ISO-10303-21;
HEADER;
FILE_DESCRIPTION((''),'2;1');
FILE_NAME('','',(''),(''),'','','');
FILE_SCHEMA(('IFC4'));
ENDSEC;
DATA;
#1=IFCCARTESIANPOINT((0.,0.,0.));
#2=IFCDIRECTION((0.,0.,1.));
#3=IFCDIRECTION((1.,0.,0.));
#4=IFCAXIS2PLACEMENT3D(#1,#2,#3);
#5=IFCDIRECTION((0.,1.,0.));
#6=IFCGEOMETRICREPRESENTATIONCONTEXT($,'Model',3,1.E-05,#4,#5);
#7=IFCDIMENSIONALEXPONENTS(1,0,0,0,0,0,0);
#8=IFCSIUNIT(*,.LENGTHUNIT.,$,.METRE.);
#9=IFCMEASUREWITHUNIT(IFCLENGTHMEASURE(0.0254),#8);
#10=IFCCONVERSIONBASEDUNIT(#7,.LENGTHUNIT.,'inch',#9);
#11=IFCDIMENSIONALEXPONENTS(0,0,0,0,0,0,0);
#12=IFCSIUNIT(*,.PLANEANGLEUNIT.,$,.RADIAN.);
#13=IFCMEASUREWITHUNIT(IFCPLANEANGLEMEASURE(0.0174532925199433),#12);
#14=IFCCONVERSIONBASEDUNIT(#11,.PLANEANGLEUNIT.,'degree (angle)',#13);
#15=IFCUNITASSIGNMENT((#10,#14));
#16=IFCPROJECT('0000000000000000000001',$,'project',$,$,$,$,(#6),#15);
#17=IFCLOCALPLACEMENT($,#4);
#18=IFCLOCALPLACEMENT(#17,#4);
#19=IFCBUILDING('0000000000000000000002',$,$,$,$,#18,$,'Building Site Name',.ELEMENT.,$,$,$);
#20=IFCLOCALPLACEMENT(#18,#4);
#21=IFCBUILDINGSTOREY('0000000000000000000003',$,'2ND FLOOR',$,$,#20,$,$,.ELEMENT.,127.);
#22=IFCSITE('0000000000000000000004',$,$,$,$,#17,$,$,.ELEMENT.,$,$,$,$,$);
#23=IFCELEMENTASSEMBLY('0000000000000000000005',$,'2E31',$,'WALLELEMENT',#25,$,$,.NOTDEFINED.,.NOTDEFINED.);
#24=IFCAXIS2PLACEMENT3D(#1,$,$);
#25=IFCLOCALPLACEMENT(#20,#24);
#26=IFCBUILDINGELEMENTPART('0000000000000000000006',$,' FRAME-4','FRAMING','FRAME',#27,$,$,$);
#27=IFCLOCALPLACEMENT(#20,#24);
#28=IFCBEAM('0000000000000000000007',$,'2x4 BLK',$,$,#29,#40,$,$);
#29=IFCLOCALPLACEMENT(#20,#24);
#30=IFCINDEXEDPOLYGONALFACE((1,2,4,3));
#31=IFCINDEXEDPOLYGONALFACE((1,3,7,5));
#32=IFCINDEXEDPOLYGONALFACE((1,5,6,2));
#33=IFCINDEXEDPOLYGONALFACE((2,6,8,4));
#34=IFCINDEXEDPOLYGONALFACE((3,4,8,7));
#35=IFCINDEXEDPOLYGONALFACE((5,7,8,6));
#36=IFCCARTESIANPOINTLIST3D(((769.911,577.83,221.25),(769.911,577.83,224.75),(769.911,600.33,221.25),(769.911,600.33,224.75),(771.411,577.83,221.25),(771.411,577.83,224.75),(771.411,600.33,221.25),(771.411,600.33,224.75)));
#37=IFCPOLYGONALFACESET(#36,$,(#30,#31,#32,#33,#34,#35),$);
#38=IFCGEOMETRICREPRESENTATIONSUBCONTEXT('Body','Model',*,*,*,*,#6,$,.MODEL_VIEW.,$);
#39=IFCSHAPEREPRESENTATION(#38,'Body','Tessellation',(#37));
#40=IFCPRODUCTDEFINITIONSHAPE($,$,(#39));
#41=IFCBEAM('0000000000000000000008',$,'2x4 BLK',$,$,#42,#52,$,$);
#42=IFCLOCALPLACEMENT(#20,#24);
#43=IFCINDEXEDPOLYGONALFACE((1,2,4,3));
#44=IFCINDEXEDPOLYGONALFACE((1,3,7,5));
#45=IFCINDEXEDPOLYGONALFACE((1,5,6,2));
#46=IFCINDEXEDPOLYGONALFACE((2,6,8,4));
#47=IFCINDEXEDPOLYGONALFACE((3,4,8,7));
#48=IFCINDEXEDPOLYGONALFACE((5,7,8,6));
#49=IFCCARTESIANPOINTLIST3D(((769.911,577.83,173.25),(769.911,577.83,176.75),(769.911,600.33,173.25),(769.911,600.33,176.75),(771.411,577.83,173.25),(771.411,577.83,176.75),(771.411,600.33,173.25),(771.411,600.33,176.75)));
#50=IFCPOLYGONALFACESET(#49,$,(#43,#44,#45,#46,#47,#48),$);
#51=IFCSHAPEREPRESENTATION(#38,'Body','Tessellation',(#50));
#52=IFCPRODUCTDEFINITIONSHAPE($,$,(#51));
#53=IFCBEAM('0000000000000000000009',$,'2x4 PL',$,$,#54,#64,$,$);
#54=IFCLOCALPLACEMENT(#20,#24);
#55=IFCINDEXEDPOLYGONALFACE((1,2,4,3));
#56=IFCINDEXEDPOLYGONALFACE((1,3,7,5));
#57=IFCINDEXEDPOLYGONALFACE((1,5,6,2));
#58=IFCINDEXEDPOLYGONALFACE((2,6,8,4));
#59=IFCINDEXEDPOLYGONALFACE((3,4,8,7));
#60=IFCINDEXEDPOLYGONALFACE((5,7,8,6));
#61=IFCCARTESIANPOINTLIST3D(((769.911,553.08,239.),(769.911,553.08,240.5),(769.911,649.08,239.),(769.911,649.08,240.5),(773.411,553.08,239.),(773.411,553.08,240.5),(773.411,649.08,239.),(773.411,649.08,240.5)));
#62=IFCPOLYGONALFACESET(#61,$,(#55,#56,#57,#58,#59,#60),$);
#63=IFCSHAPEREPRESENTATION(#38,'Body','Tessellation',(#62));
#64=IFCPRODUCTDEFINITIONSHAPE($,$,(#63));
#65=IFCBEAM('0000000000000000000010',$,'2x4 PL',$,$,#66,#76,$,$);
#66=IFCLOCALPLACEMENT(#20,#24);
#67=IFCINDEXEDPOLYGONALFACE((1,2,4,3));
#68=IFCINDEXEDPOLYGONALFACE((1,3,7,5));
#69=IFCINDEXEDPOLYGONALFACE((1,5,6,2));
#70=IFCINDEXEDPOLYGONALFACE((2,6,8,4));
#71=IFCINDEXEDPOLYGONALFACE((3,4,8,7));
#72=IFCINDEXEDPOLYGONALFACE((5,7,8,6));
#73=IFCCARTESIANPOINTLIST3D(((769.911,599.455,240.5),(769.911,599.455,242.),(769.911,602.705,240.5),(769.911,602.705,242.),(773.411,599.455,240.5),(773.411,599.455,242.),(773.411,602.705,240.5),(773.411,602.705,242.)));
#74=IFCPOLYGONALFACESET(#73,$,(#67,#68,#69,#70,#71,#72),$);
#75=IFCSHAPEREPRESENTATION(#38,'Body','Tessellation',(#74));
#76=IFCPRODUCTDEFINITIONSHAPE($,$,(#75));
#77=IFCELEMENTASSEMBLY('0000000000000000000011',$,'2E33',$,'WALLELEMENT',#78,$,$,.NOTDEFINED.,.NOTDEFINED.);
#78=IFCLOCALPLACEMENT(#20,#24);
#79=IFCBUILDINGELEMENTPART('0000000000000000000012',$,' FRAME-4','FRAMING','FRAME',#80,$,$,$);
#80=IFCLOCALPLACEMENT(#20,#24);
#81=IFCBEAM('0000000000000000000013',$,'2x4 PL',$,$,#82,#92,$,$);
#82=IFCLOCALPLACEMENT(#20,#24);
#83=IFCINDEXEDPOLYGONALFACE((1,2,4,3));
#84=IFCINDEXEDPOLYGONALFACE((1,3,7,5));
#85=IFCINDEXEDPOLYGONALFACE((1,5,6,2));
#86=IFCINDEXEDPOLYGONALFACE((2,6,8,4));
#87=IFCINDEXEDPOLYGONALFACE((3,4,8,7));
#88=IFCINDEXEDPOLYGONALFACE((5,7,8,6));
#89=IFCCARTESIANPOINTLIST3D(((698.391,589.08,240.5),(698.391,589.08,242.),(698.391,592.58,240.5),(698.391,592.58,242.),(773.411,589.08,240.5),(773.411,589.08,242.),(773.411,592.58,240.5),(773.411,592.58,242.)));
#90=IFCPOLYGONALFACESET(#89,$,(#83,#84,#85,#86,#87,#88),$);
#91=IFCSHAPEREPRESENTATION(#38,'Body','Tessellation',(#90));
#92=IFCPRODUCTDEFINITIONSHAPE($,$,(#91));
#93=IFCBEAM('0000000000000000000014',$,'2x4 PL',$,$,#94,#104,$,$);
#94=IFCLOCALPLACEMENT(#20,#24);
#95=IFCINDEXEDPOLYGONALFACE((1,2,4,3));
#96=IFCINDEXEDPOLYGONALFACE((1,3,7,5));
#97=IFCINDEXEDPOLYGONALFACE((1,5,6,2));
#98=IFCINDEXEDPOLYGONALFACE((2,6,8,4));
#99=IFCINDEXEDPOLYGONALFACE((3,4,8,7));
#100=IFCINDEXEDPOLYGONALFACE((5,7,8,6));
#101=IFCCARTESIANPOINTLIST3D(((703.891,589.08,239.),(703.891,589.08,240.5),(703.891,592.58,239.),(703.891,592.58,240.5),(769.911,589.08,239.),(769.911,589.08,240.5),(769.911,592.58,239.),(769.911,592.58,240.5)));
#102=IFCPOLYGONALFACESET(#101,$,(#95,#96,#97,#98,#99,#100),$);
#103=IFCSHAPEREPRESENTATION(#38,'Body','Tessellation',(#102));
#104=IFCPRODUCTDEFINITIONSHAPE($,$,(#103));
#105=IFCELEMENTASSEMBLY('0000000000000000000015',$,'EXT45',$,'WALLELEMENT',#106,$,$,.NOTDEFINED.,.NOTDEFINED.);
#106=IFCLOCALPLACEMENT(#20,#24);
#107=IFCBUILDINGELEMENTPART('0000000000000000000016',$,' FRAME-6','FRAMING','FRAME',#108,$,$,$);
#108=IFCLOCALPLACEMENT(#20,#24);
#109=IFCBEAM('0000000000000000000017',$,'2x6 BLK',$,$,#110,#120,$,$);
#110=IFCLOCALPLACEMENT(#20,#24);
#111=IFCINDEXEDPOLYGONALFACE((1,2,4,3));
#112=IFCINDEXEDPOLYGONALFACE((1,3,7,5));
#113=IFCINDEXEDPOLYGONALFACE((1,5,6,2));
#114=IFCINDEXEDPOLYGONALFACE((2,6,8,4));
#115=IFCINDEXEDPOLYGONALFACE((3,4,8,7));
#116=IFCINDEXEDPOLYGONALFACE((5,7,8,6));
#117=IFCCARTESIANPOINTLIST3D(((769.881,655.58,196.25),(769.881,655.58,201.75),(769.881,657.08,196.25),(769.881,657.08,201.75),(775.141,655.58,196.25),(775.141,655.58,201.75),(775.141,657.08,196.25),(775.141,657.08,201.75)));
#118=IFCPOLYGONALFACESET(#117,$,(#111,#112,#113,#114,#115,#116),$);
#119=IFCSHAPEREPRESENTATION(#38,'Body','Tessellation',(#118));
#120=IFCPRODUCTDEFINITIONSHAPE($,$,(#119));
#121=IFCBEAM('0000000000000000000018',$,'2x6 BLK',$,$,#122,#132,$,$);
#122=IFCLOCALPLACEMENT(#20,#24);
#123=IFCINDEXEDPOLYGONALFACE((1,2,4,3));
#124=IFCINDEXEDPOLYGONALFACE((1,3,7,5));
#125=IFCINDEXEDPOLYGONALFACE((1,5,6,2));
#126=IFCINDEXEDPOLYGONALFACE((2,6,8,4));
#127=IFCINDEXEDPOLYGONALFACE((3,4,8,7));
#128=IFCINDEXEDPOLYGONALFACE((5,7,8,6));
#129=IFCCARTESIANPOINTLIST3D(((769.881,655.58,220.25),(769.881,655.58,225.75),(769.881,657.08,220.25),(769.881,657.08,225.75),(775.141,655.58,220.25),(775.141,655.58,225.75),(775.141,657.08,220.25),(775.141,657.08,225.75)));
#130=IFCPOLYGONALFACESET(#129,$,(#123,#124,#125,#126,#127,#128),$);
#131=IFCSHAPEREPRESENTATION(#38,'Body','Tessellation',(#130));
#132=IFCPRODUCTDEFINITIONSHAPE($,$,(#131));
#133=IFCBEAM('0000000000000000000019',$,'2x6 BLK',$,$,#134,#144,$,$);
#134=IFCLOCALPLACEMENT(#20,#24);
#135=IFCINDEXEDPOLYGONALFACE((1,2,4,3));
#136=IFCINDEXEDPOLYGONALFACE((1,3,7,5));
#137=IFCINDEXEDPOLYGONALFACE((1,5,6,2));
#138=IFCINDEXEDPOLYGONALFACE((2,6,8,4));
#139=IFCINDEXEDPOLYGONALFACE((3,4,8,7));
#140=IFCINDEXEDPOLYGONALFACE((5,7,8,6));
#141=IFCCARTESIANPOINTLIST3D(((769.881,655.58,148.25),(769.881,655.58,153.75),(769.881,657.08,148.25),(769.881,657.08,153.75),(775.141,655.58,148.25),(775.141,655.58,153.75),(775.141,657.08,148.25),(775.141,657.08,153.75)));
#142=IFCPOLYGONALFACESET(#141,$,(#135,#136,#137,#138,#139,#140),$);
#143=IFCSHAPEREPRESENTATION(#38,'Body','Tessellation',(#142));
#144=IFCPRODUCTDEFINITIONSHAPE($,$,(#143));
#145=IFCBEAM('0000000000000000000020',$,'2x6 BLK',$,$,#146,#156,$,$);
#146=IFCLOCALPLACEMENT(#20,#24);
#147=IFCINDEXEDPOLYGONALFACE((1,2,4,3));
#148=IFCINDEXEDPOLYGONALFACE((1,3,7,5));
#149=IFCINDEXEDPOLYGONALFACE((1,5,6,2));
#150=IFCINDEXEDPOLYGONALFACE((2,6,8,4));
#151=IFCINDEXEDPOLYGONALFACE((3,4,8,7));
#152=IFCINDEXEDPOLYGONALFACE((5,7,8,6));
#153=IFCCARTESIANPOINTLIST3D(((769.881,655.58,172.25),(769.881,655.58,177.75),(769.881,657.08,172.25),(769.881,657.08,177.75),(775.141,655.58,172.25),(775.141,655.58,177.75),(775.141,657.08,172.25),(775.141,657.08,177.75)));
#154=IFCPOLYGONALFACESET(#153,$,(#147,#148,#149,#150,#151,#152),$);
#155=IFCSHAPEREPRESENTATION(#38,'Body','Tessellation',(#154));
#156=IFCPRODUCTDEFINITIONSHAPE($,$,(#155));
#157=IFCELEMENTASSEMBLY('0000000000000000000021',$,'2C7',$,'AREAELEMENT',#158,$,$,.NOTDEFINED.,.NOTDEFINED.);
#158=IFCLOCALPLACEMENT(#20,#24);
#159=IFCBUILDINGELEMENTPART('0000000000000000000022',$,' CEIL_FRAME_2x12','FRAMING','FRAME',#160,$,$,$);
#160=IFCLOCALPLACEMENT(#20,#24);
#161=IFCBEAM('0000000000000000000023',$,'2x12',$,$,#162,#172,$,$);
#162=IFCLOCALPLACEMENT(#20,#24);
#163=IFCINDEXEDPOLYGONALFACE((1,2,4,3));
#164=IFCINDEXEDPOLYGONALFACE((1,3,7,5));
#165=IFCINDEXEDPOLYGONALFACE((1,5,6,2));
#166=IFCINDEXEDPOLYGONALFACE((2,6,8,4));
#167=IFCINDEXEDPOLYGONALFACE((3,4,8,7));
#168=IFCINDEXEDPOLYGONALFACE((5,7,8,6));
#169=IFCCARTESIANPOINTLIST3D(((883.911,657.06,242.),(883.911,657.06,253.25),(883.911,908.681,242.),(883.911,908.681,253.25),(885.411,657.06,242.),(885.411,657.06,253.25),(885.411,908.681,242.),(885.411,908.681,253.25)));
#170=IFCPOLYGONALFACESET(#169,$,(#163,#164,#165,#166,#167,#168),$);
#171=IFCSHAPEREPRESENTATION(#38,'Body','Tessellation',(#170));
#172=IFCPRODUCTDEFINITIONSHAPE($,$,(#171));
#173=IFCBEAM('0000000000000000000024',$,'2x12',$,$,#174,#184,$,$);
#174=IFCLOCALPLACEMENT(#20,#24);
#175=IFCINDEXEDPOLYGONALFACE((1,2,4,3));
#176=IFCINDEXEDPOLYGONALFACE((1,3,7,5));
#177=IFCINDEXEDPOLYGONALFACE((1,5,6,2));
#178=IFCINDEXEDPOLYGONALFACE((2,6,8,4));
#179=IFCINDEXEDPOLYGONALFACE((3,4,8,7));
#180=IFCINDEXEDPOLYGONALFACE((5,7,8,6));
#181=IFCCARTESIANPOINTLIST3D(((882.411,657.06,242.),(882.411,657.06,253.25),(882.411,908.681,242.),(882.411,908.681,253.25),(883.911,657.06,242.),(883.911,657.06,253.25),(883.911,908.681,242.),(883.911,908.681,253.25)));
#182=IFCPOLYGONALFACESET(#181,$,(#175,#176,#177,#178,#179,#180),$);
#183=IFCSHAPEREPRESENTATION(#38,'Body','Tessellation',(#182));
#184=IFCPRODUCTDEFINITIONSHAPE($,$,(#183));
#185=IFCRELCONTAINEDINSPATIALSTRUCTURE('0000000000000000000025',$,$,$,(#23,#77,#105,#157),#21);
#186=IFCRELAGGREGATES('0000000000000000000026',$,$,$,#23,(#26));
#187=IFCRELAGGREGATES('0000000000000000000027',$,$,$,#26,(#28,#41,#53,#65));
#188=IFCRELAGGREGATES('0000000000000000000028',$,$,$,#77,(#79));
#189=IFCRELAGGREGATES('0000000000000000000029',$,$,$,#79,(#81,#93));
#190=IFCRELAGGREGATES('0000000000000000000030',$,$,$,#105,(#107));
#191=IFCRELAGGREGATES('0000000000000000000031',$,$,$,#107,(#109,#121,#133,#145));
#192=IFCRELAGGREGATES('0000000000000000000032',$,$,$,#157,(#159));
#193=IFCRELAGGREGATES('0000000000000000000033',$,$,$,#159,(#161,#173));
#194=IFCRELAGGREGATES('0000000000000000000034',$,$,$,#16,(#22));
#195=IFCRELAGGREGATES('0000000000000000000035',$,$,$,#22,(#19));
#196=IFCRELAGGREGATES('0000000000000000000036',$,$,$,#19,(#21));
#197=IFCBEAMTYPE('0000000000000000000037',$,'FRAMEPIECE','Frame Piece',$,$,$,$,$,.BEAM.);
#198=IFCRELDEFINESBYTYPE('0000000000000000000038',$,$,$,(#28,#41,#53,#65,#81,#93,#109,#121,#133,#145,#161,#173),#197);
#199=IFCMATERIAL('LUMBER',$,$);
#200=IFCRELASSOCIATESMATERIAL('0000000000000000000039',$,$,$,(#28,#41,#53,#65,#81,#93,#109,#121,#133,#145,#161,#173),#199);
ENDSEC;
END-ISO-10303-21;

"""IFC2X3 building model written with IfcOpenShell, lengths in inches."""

from ifc_helpers import new_model, entity, si_unit, converted_unit, direction, frame, frame_2d, origin_with_axes, place, context, subcontext, project, spatial, rectangle, extrude, material, type_object, element, aggregate, save


model = new_model("IFC2X3")

# Units and contexts
model_context = context("Model", 3, precision=1e-05, world=origin_with_axes(), true_north=direction((0.0, 1.0, 0.0)))
body_context = subcontext(model_context, "Body", "Model", "MODEL_VIEW")
ifc_project = project(units=[converted_unit("LENGTHUNIT", "inch", entity("IfcLengthMeasure", 0.0254), si_unit("LENGTHUNIT", "METRE"), dimensions=[1, 0, 0, 0, 0, 0, 0]), converted_unit("PLANEANGLEUNIT", "degree (angle)", entity("IfcPlaneAngleMeasure", 0.0174532925199433), si_unit("PLANEANGLEUNIT", "RADIAN"), dimensions=[0, 0, 0, 0, 0, 0, 0])], contexts=[model_context])

# Site, building, storey
site_placement = place(None, origin_with_axes())
site = spatial("IfcSite", under=ifc_project, at=site_placement, CompositionType="ELEMENT")
building_placement = place(site_placement, origin_with_axes())
building = spatial("IfcBuilding", under=site, at=building_placement, LongName="Building Site Name", CompositionType="ELEMENT")
storey_placement = place(building_placement, origin_with_axes())
storey = spatial("IfcBuildingStorey", under=building, at=storey_placement, Name="2ND FLOOR", CompositionType="ELEMENT", Elevation=127.0)

# Shared definitions
ifc_material = material(Name="LUMBER")
beam_type = type_object("IfcBeamType", Name="FRAMEPIECE", Description="Frame Piece", PredefinedType="BEAM")

# Element assembly, building element part
assembly_1_placement = place(storey_placement, origin_with_axes())
assembly_1 = element("IfcElementAssembly", 1, at=assembly_1_placement, inside=storey, Name="2E31", ObjectType="WALLELEMENT", AssemblyPlace="NOTDEFINED", PredefinedType="NOTDEFINED")
building_element_part_1 = element("IfcBuildingElementPart", 2, Name=" FRAME-4", Description="FRAMING", ObjectType="FRAME")
aggregate(assembly_1, [building_element_part_1])

# Beams
beam_1_placement = place(assembly_1_placement, frame((770.661, 600.33, 223.0), z_axis=(0.0, -1.0, 0.0), x_axis=(-1.0, 0.0, 0.0)))
beam_1 = element("IfcBeam", 3, at=beam_1_placement, type_object=beam_type, material=ifc_material, Name="2x4 BLK", context=body_context, shape_type="SweptSolid", body=[
    extrude(rectangle(XDim=1.5, YDim=3.5, at=frame_2d((0.0, 0.0), x_axis=(-1.0, 0.0))), origin_with_axes(), (0.0, 0.0, 1.0), 22.5),
])
beam_2_placement = place(assembly_1_placement, frame((770.661, 600.33, 175.0), z_axis=(0.0, -1.0, 0.0), x_axis=(-1.0, 0.0, 0.0)))
beam_2 = element("IfcBeam", 4, at=beam_2_placement, type_object=beam_type, material=ifc_material, Name="2x4 BLK", context=body_context, shape_type="SweptSolid", body=[
    extrude(rectangle(XDim=1.5, YDim=3.5, at=frame_2d((0.0, 0.0), x_axis=(-1.0, 0.0))), origin_with_axes(), (0.0, 0.0, 1.0), 22.5),
])
beam_3_placement = place(assembly_1_placement, frame((771.661, 649.08, 239.75), z_axis=(0.0, -1.0, 0.0), x_axis=(0.0, 0.0, -1.0)))
beam_3 = element("IfcBeam", 5, at=beam_3_placement, type_object=beam_type, material=ifc_material, Name="2x4 PL", context=body_context, shape_type="SweptSolid", body=[
    extrude(rectangle(XDim=1.5, YDim=3.5, at=frame_2d((0.0, 0.0), x_axis=(-1.0, 0.0))), origin_with_axes(), (0.0, 0.0, 1.0), 96.0),
])
beam_4_placement = place(assembly_1_placement, frame((771.661, 602.705, 241.25), z_axis=(0.0, -1.0, 0.0), x_axis=(0.0, 0.0, -1.0)))
beam_4 = element("IfcBeam", 6, at=beam_4_placement, type_object=beam_type, material=ifc_material, Name="2x4 PL", context=body_context, shape_type="SweptSolid", body=[
    extrude(rectangle(XDim=1.5, YDim=3.5, at=frame_2d((0.0, 0.0), x_axis=(-1.0, 0.0))), origin_with_axes(), (0.0, 0.0, 1.0), 3.25),
])
aggregate(building_element_part_1, [beam_1, beam_2, beam_3, beam_4])

# Element assemblies, building element parts, beams
assembly_2_placement = place(storey_placement, origin_with_axes())
assembly_2 = element("IfcElementAssembly", 7, at=assembly_2_placement, inside=storey, Name="2E33", ObjectType="WALLELEMENT", AssemblyPlace="NOTDEFINED", PredefinedType="NOTDEFINED")
building_element_part_2 = element("IfcBuildingElementPart", 8, Name=" FRAME-4", Description="FRAMING", ObjectType="FRAME")
aggregate(assembly_2, [building_element_part_2])
beam_5_placement = place(assembly_2_placement, frame((773.411, 590.83, 241.25), z_axis=(-1.0, 0.0, 0.0), x_axis=(0.0, 0.0, -1.0)))
beam_5 = element("IfcBeam", 9, at=beam_5_placement, type_object=beam_type, material=ifc_material, Name="2x4 PL", context=body_context, shape_type="SweptSolid", body=[
    extrude(rectangle(XDim=1.5, YDim=3.5, at=frame_2d((0.0, 0.0), x_axis=(-1.0, 0.0))), origin_with_axes(), (0.0, 0.0, 1.0), 75.02),
])
beam_6_placement = place(assembly_2_placement, frame((769.911, 590.83, 239.75), z_axis=(-1.0, 0.0, 0.0), x_axis=(0.0, 0.0, -1.0)))
beam_6 = element("IfcBeam", 10, at=beam_6_placement, type_object=beam_type, material=ifc_material, Name="2x4 PL", context=body_context, shape_type="SweptSolid", body=[
    extrude(rectangle(XDim=1.5, YDim=3.5, at=frame_2d((0.0, 0.0), x_axis=(-1.0, 0.0))), origin_with_axes(), (0.0, 0.0, 1.0), 66.02),
])
aggregate(building_element_part_2, [beam_5, beam_6])
assembly_3_placement = place(storey_placement, origin_with_axes())
assembly_3 = element("IfcElementAssembly", 11, at=assembly_3_placement, inside=storey, Name="EXT45", ObjectType="WALLELEMENT", AssemblyPlace="NOTDEFINED", PredefinedType="NOTDEFINED")
building_element_part_3 = element("IfcBuildingElementPart", 12, Name=" FRAME-6", Description="FRAMING", ObjectType="FRAME")
aggregate(assembly_3, [building_element_part_3])
beam_7_placement = place(assembly_3_placement, frame((775.141, 656.33, 199.0), z_axis=(-1.0, 0.0, 0.0), x_axis=(0.0, 1.0, 0.0)))
beam_7 = element("IfcBeam", 13, at=beam_7_placement, type_object=beam_type, material=ifc_material, Name="2x6 BLK", context=body_context, shape_type="SweptSolid", body=[
    extrude(rectangle(XDim=1.5, YDim=5.5, at=frame_2d((0.0, 0.0), x_axis=(-1.0, 0.0))), origin_with_axes(), (0.0, 0.0, 1.0), 5.26),
])
beam_8_placement = place(assembly_3_placement, frame((775.141, 656.33, 223.0), z_axis=(-1.0, 0.0, 0.0), x_axis=(0.0, 1.0, 0.0)))
beam_8 = element("IfcBeam", 14, at=beam_8_placement, type_object=beam_type, material=ifc_material, Name="2x6 BLK", context=body_context, shape_type="SweptSolid", body=[
    extrude(rectangle(XDim=1.5, YDim=5.5, at=frame_2d((0.0, 0.0), x_axis=(-1.0, 0.0))), origin_with_axes(), (0.0, 0.0, 1.0), 5.26),
])
beam_9_placement = place(assembly_3_placement, frame((775.141, 656.33, 151.0), z_axis=(-1.0, 0.0, 0.0), x_axis=(0.0, 1.0, 0.0)))
beam_9 = element("IfcBeam", 15, at=beam_9_placement, type_object=beam_type, material=ifc_material, Name="2x6 BLK", context=body_context, shape_type="SweptSolid", body=[
    extrude(rectangle(XDim=1.5, YDim=5.5, at=frame_2d((0.0, 0.0), x_axis=(-1.0, 0.0))), origin_with_axes(), (0.0, 0.0, 1.0), 5.26),
])
beam_10_placement = place(assembly_3_placement, frame((775.141, 656.33, 175.0), z_axis=(-1.0, 0.0, 0.0), x_axis=(0.0, 1.0, 0.0)))
beam_10 = element("IfcBeam", 16, at=beam_10_placement, type_object=beam_type, material=ifc_material, Name="2x6 BLK", context=body_context, shape_type="SweptSolid", body=[
    extrude(rectangle(XDim=1.5, YDim=5.5, at=frame_2d((0.0, 0.0), x_axis=(-1.0, 0.0))), origin_with_axes(), (0.0, 0.0, 1.0), 5.26),
])
aggregate(building_element_part_3, [beam_7, beam_8, beam_9, beam_10])
assembly_4_placement = place(storey_placement, origin_with_axes())
assembly_4 = element("IfcElementAssembly", 17, at=assembly_4_placement, inside=storey, Name="2C7", ObjectType="AREAELEMENT", AssemblyPlace="NOTDEFINED", PredefinedType="NOTDEFINED")
building_element_part_4 = element("IfcBuildingElementPart", 18, Name=" CEIL_FRAME_2x12", Description="FRAMING", ObjectType="FRAME")
aggregate(assembly_4, [building_element_part_4])
beam_11_placement = place(assembly_4_placement, frame((884.661, 657.06, 247.625), z_axis=(0.0, 1.0, 0.0), x_axis=(-1.0, 0.0, 0.0)))
beam_11 = element("IfcBeam", 19, at=beam_11_placement, type_object=beam_type, material=ifc_material, Name="2x12", context=body_context, shape_type="SweptSolid", body=[
    extrude(rectangle(XDim=1.5, YDim=11.25, at=frame_2d((0.0, 0.0), x_axis=(-1.0, 0.0))), origin_with_axes(), (0.0, 0.0, 1.0), 251.621),
])
beam_12_placement = place(assembly_4_placement, frame((883.161, 657.06, 247.625), z_axis=(0.0, 1.0, 0.0), x_axis=(-1.0, 0.0, 0.0)))
beam_12 = element("IfcBeam", 20, at=beam_12_placement, type_object=beam_type, material=ifc_material, Name="2x12", context=body_context, shape_type="SweptSolid", body=[
    extrude(rectangle(XDim=1.5, YDim=11.25, at=frame_2d((0.0, 0.0), x_axis=(-1.0, 0.0))), origin_with_axes(), (0.0, 0.0, 1.0), 251.621),
])
aggregate(building_element_part_4, [beam_11, beam_12])

save(model, "model.ifc")
